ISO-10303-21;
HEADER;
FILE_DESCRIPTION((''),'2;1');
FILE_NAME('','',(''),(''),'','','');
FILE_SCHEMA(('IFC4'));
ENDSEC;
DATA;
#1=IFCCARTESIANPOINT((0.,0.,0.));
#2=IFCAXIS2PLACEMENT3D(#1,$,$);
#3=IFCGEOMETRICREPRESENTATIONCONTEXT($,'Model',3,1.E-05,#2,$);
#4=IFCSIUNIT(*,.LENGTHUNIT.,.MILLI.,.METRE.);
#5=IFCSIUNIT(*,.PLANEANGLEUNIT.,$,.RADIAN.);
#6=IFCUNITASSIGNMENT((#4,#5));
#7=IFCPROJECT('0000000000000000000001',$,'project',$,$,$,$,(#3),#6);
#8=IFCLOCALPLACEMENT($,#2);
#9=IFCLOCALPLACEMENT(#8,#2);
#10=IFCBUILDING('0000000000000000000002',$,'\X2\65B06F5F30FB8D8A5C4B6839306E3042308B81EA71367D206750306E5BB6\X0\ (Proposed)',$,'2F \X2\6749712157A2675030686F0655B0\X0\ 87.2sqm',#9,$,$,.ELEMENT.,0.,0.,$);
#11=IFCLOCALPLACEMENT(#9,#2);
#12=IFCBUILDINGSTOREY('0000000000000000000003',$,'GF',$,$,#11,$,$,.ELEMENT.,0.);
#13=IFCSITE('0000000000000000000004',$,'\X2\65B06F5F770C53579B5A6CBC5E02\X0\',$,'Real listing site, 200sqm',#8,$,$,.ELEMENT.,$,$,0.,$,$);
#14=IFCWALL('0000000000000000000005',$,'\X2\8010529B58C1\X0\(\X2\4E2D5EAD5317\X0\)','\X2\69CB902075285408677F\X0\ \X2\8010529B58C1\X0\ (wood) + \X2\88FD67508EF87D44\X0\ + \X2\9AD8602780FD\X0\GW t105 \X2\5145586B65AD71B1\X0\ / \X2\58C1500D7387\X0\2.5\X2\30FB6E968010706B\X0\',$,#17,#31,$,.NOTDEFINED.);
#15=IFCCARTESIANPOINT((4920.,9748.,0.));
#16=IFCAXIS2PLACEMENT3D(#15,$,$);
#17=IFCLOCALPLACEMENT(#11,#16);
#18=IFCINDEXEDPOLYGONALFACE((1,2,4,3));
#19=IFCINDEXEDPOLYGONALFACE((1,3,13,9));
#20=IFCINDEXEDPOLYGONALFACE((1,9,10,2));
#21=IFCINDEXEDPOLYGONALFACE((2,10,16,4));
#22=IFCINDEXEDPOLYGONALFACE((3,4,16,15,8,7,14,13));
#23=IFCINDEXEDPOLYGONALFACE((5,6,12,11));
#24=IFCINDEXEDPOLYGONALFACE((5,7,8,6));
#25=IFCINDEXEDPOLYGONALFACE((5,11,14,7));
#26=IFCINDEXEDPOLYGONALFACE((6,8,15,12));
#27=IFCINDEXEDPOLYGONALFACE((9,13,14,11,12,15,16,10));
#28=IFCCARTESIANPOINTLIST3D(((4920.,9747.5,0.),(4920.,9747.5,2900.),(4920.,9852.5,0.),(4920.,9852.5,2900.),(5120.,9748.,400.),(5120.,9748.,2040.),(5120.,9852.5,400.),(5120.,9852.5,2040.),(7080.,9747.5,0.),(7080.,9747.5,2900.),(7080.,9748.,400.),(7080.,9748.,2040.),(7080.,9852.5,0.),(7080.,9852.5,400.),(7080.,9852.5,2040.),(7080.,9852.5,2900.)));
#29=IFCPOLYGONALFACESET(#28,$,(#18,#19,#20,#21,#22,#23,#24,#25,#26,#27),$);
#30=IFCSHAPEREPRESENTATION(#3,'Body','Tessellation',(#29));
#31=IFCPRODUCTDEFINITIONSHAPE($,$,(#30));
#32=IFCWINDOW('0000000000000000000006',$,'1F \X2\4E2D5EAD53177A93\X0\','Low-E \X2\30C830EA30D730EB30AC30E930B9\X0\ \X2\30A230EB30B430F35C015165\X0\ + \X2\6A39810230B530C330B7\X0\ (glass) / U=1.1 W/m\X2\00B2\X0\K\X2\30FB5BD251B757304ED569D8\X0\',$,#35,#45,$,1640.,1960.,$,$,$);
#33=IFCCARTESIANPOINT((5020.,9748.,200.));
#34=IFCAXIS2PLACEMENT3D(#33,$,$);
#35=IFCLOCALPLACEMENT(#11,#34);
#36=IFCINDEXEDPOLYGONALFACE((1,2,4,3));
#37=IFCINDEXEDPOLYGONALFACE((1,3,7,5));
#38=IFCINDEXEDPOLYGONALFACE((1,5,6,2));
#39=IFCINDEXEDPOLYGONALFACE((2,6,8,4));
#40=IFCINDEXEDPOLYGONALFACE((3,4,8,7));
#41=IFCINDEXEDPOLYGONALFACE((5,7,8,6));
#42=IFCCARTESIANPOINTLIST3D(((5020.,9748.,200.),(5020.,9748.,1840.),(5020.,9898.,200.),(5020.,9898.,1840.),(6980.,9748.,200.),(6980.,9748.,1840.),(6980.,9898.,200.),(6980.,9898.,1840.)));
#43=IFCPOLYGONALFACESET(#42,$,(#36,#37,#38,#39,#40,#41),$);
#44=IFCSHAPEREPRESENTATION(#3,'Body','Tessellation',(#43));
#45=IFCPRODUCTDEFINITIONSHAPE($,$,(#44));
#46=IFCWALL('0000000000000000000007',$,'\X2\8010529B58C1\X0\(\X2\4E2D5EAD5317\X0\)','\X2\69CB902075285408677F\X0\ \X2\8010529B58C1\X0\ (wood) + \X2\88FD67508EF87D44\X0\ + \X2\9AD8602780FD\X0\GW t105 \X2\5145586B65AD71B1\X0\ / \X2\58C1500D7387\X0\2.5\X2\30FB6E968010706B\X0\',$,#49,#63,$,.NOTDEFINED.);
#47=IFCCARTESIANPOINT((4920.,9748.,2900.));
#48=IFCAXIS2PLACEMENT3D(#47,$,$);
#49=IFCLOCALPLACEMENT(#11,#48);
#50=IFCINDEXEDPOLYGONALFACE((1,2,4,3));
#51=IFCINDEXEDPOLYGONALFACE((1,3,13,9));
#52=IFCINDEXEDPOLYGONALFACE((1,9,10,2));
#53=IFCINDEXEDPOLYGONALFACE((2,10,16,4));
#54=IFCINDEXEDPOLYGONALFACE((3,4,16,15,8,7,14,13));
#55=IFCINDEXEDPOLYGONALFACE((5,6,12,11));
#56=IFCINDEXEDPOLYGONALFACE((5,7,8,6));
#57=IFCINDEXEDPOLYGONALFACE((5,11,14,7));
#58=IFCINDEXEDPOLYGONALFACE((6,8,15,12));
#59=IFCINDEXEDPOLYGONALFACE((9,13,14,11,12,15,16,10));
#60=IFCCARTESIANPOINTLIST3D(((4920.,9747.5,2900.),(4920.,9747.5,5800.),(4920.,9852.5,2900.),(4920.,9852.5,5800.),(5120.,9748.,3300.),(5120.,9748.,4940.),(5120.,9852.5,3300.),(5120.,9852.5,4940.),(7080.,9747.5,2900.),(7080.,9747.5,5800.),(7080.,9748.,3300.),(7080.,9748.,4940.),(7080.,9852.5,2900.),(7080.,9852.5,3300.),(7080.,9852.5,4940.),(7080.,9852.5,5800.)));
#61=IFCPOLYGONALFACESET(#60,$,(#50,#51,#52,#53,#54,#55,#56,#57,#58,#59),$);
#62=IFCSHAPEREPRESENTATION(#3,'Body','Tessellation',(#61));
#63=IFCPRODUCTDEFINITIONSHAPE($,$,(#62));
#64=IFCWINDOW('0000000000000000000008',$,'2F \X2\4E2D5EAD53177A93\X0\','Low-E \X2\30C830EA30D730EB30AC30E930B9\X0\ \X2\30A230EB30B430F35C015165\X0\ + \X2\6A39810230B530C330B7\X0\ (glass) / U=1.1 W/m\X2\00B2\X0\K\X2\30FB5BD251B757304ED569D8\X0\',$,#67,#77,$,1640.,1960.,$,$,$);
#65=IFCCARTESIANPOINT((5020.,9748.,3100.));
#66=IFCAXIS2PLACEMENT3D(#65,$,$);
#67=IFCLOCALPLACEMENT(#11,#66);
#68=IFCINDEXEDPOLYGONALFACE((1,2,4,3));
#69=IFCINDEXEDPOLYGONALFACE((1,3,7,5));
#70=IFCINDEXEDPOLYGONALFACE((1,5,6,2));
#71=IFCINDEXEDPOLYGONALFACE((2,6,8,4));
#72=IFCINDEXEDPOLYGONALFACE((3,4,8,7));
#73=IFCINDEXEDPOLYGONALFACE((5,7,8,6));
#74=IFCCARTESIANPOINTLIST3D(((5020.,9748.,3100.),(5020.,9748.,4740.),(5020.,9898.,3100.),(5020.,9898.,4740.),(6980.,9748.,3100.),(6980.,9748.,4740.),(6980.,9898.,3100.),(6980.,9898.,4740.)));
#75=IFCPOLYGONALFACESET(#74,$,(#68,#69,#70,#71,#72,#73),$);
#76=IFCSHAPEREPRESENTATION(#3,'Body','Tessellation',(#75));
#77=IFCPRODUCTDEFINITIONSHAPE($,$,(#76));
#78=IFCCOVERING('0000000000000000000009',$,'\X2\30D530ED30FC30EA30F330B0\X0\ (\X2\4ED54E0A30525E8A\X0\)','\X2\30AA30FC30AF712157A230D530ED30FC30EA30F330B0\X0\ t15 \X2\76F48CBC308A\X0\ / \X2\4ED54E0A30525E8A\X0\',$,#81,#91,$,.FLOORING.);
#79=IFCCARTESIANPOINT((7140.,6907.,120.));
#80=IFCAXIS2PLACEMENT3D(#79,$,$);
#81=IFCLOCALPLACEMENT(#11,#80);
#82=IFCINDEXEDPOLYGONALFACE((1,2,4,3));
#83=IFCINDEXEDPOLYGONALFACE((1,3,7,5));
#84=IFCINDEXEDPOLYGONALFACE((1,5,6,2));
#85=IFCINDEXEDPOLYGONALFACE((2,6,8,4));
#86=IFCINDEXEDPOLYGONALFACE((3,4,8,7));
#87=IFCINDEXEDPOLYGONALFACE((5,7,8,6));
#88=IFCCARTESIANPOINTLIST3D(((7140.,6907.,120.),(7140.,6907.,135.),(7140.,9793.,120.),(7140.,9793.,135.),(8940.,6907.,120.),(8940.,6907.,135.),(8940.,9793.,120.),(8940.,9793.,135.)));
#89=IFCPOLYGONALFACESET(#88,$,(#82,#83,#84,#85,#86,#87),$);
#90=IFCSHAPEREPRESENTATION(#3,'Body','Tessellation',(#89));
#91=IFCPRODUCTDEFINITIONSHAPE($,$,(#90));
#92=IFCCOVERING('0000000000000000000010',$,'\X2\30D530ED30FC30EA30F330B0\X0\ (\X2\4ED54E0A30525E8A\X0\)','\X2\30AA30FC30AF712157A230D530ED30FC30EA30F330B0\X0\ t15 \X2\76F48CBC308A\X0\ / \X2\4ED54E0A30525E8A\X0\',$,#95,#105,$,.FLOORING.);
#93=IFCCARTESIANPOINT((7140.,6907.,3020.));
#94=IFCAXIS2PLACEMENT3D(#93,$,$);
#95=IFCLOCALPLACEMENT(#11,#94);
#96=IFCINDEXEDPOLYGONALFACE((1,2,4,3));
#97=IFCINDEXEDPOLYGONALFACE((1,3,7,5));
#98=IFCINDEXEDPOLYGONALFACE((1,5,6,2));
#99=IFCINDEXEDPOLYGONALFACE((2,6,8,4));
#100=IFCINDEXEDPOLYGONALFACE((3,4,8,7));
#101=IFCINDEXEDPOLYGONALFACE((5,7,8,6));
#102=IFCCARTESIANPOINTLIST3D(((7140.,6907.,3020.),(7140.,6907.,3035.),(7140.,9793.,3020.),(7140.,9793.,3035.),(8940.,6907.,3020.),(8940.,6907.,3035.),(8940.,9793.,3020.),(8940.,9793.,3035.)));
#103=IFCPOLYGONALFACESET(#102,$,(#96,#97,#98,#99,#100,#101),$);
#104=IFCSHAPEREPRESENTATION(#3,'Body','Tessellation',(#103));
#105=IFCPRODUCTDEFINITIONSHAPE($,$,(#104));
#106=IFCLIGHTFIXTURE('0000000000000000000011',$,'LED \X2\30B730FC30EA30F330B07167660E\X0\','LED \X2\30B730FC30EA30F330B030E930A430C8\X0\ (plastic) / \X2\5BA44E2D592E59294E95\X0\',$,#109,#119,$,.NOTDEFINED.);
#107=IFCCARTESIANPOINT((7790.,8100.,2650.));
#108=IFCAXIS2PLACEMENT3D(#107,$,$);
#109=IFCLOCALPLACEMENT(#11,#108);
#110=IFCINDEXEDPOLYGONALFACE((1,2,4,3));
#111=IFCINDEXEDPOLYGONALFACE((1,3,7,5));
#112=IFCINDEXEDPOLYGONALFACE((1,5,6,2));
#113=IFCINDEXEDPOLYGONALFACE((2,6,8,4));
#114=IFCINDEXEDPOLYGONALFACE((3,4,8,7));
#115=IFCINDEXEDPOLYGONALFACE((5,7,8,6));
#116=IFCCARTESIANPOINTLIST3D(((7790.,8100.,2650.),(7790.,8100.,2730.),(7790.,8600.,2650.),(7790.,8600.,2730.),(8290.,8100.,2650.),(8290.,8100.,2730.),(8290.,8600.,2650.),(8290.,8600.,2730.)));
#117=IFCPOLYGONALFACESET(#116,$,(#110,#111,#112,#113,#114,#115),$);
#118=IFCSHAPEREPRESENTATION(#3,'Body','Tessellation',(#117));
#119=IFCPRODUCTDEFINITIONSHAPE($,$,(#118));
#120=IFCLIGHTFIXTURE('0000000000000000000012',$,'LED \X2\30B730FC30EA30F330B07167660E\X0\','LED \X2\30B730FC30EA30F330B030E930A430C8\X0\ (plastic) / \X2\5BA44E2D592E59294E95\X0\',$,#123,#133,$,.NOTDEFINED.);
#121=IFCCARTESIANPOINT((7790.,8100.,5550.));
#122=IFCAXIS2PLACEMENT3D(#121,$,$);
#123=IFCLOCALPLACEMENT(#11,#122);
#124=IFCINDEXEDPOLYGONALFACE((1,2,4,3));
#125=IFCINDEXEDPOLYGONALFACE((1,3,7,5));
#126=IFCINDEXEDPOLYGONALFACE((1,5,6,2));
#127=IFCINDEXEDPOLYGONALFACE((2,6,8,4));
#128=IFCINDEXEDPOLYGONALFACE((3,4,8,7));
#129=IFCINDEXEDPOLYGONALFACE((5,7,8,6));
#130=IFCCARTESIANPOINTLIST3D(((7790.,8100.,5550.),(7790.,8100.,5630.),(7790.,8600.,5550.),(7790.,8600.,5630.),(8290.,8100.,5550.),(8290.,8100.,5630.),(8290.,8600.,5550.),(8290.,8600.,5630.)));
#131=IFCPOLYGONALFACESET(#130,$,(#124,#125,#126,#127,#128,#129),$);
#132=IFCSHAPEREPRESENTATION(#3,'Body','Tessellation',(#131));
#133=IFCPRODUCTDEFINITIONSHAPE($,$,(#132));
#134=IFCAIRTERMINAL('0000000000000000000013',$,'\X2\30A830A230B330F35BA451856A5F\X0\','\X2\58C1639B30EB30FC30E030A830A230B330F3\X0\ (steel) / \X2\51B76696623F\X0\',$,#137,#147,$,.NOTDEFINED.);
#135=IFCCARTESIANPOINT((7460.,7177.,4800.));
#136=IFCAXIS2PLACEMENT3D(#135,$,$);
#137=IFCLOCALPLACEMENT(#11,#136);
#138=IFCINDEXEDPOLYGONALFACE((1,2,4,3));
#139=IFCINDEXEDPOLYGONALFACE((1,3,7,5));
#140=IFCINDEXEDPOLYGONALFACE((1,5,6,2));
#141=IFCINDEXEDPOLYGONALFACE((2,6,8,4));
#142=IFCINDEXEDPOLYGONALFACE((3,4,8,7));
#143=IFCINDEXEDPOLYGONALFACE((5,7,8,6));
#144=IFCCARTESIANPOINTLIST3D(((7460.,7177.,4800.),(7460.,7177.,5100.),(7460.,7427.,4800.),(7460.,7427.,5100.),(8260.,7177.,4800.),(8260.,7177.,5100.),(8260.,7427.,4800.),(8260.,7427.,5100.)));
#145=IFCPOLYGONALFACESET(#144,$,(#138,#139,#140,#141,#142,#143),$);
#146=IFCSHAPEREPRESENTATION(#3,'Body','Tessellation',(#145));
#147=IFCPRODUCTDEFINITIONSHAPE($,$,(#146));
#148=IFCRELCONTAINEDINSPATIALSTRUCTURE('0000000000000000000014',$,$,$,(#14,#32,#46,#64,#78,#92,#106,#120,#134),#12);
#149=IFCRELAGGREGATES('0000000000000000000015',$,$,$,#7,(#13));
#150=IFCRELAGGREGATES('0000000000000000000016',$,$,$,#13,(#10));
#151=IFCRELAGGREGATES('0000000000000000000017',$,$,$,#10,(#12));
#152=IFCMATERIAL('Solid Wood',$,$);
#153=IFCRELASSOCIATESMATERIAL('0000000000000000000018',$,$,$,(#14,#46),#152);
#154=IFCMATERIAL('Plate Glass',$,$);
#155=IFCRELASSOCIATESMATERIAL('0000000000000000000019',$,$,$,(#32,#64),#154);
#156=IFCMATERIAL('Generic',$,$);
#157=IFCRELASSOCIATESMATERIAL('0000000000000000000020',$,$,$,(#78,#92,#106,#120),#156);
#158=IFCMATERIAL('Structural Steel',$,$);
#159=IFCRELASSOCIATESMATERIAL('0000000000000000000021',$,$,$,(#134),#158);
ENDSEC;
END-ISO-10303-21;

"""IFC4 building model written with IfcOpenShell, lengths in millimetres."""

from ifc_helpers import new_model, si_unit, frame, frame_2d, origin, place, context, project, spatial, rectangle, extrude, material, element, fill, save


model = new_model("IFC4")

# Units and contexts
model_context = context("Model", 3, precision=1e-05, world=origin())
ifc_project = project(units=[si_unit("LENGTHUNIT", "METRE", prefix="MILLI"), si_unit("PLANEANGLEUNIT", "RADIAN")], contexts=[model_context])

# Site, building, storey
site_placement = place(None, origin())
site = spatial("IfcSite", under=ifc_project, at=site_placement, Name="新潟県南魚沼市", ObjectType="Real listing site, 200sqm", CompositionType="ELEMENT", RefElevation=0.0)
building_placement = place(site_placement, origin())
building = spatial("IfcBuilding", under=site, at=building_placement, Name="新潟・越屋根のある自然素材の家 (Proposed)", ObjectType="2F 杉無垢材と漆喰 87.2sqm", CompositionType="ELEMENT", ElevationOfRefHeight=0.0, ElevationOfTerrain=0.0)
storey_placement = place(building_placement, origin())
storey = spatial("IfcBuildingStorey", under=building, at=storey_placement, Name="GF", CompositionType="ELEMENT", Elevation=0.0)

# Shared definitions
ifc_material_1 = material(Name="Solid Wood")

# Walls, openings, windows
wall_1_placement = place(storey_placement, frame((4920.0, 9748.0, 0.0)))
wall_1 = element("IfcWall", 1, at=wall_1_placement, inside=storey, material=ifc_material_1, Name="耐力壁(中庭北)", Description="構造用合板 耐力壁 (wood) + 製材軸組 + 高性能GW t105 充填断熱 / 壁倍率2.5・準耐火", PredefinedType="NOTDEFINED", context=model_context, shape_type="SweptSolid", body=[
    extrude(rectangle(XDim=2160.0, YDim=105.0, at=frame_2d((1080.0, 52.0))), frame((4920.0, 9748.0, 0.0)), (0.0, 0.0, 1.0), 2900.0),
])
opening_1_placement = place(storey_placement, frame((5020.0, 9748.0, 200.0)))
opening_1 = element("IfcOpeningElement", 2, at=opening_1_placement, cuts=wall_1, PredefinedType="NOTDEFINED", context=model_context, shape_type="SweptSolid", body=[
    extrude(rectangle(XDim=1960.0, YDim=150.0, at=frame_2d((980.0, 75.0))), frame((5020.0, 9748.0, 200.0)), (0.0, 0.0, 1.0), 1640.0),
])
ifc_material_2 = material(Name="Plate Glass")
window_1_placement = place(storey_placement, frame((5020.0, 9748.0, 200.0)))
window_1 = element("IfcWindow", 3, at=window_1_placement, inside=storey, material=ifc_material_2, Name="1F 中庭北窓", Description="Low-E トリプルガラス アルゴン封入 + 樹脂サッシ (glass) / U=1.1 W/m²K・寒冷地仕様", OverallHeight=1640.0, OverallWidth=1960.0, context=model_context, shape_type="SweptSolid", body=[
    extrude(rectangle(XDim=1960.0, YDim=150.0, at=frame_2d((980.0, 75.0))), frame((5020.0, 9748.0, 200.0)), (0.0, 0.0, 1.0), 1640.0),
])
fill(opening_1, window_1)
wall_2_placement = place(storey_placement, frame((4920.0, 9748.0, 2900.0)))
wall_2 = element("IfcWall", 4, at=wall_2_placement, inside=storey, material=ifc_material_1, Name="耐力壁(中庭北)", Description="構造用合板 耐力壁 (wood) + 製材軸組 + 高性能GW t105 充填断熱 / 壁倍率2.5・準耐火", PredefinedType="NOTDEFINED", context=model_context, shape_type="SweptSolid", body=[
    extrude(rectangle(XDim=2160.0, YDim=105.0, at=frame_2d((1080.0, 52.0))), frame((4920.0, 9748.0, 2900.0)), (0.0, 0.0, 1.0), 2900.0),
])
opening_2_placement = place(storey_placement, frame((5020.0, 9748.0, 3100.0)))
opening_2 = element("IfcOpeningElement", 5, at=opening_2_placement, cuts=wall_2, PredefinedType="NOTDEFINED", context=model_context, shape_type="SweptSolid", body=[
    extrude(rectangle(XDim=1960.0, YDim=150.0, at=frame_2d((980.0, 75.0))), frame((5020.0, 9748.0, 3100.0)), (0.0, 0.0, 1.0), 1640.0),
])
window_2_placement = place(storey_placement, frame((5020.0, 9748.0, 3100.0)))
window_2 = element("IfcWindow", 6, at=window_2_placement, inside=storey, material=ifc_material_2, Name="2F 中庭北窓", Description="Low-E トリプルガラス アルゴン封入 + 樹脂サッシ (glass) / U=1.1 W/m²K・寒冷地仕様", OverallHeight=1640.0, OverallWidth=1960.0, context=model_context, shape_type="SweptSolid", body=[
    extrude(rectangle(XDim=1960.0, YDim=150.0, at=frame_2d((980.0, 75.0))), frame((5020.0, 9748.0, 3100.0)), (0.0, 0.0, 1.0), 1640.0),
])
fill(opening_2, window_2)

# Coverings
ifc_material_3 = material(Name="Generic")
covering_1_placement = place(storey_placement, frame((7140.0, 6907.0, 120.0)))
element("IfcCovering", 7, at=covering_1_placement, inside=storey, material=ifc_material_3, Name="フローリング (仕上げ床)", Description="オーク無垢フローリング t15 直貼り / 仕上げ床", PredefinedType="FLOORING", context=model_context, shape_type="SweptSolid", body=[
    extrude(rectangle(XDim=1800.0, YDim=2886.0, at=frame_2d((900.0, 1443.0))), frame((7140.0, 6907.0, 120.0)), (0.0, 0.0, 1.0), 15.0),
])
covering_2_placement = place(storey_placement, frame((7140.0, 6907.0, 3020.0)))
element("IfcCovering", 8, at=covering_2_placement, inside=storey, material=ifc_material_3, Name="フローリング (仕上げ床)", Description="オーク無垢フローリング t15 直貼り / 仕上げ床", PredefinedType="FLOORING", context=model_context, shape_type="SweptSolid", body=[
    extrude(rectangle(XDim=1800.0, YDim=2886.0, at=frame_2d((900.0, 1443.0))), frame((7140.0, 6907.0, 3020.0)), (0.0, 0.0, 1.0), 15.0),
])

# Light fixtures
light_fixture_1_placement = place(storey_placement, frame((7790.0, 8100.0, 2650.0)))
element("IfcLightFixture", 9, at=light_fixture_1_placement, inside=storey, material=ifc_material_3, Name="LED シーリング照明", Description="LED シーリングライト (plastic) / 室中央天井", PredefinedType="NOTDEFINED", context=model_context, shape_type="SweptSolid", body=[
    extrude(rectangle(XDim=500.0, YDim=500.0, at=frame_2d((250.0, 250.0))), frame((7790.0, 8100.0, 2650.0)), (0.0, 0.0, 1.0), 80.0),
])
light_fixture_2_placement = place(storey_placement, frame((7790.0, 8100.0, 5550.0)))
element("IfcLightFixture", 10, at=light_fixture_2_placement, inside=storey, material=ifc_material_3, Name="LED シーリング照明", Description="LED シーリングライト (plastic) / 室中央天井", PredefinedType="NOTDEFINED", context=model_context, shape_type="SweptSolid", body=[
    extrude(rectangle(XDim=500.0, YDim=500.0, at=frame_2d((250.0, 250.0))), frame((7790.0, 8100.0, 5550.0)), (0.0, 0.0, 1.0), 80.0),
])

# Air terminal
ifc_material_4 = material(Name="Structural Steel")
air_terminal_placement = place(storey_placement, frame((7460.0, 7177.0, 4800.0)))
element("IfcAirTerminal", 11, at=air_terminal_placement, inside=storey, material=ifc_material_4, Name="エアコン室内機", Description="壁掛ルームエアコン (steel) / 冷暖房", PredefinedType="NOTDEFINED", context=model_context, shape_type="SweptSolid", body=[
    extrude(rectangle(XDim=800.0, YDim=250.0, at=frame_2d((400.0, 125.0))), frame((7460.0, 7177.0, 4800.0)), (0.0, 0.0, 1.0), 300.0),
])

save(model, "model.ifc")
